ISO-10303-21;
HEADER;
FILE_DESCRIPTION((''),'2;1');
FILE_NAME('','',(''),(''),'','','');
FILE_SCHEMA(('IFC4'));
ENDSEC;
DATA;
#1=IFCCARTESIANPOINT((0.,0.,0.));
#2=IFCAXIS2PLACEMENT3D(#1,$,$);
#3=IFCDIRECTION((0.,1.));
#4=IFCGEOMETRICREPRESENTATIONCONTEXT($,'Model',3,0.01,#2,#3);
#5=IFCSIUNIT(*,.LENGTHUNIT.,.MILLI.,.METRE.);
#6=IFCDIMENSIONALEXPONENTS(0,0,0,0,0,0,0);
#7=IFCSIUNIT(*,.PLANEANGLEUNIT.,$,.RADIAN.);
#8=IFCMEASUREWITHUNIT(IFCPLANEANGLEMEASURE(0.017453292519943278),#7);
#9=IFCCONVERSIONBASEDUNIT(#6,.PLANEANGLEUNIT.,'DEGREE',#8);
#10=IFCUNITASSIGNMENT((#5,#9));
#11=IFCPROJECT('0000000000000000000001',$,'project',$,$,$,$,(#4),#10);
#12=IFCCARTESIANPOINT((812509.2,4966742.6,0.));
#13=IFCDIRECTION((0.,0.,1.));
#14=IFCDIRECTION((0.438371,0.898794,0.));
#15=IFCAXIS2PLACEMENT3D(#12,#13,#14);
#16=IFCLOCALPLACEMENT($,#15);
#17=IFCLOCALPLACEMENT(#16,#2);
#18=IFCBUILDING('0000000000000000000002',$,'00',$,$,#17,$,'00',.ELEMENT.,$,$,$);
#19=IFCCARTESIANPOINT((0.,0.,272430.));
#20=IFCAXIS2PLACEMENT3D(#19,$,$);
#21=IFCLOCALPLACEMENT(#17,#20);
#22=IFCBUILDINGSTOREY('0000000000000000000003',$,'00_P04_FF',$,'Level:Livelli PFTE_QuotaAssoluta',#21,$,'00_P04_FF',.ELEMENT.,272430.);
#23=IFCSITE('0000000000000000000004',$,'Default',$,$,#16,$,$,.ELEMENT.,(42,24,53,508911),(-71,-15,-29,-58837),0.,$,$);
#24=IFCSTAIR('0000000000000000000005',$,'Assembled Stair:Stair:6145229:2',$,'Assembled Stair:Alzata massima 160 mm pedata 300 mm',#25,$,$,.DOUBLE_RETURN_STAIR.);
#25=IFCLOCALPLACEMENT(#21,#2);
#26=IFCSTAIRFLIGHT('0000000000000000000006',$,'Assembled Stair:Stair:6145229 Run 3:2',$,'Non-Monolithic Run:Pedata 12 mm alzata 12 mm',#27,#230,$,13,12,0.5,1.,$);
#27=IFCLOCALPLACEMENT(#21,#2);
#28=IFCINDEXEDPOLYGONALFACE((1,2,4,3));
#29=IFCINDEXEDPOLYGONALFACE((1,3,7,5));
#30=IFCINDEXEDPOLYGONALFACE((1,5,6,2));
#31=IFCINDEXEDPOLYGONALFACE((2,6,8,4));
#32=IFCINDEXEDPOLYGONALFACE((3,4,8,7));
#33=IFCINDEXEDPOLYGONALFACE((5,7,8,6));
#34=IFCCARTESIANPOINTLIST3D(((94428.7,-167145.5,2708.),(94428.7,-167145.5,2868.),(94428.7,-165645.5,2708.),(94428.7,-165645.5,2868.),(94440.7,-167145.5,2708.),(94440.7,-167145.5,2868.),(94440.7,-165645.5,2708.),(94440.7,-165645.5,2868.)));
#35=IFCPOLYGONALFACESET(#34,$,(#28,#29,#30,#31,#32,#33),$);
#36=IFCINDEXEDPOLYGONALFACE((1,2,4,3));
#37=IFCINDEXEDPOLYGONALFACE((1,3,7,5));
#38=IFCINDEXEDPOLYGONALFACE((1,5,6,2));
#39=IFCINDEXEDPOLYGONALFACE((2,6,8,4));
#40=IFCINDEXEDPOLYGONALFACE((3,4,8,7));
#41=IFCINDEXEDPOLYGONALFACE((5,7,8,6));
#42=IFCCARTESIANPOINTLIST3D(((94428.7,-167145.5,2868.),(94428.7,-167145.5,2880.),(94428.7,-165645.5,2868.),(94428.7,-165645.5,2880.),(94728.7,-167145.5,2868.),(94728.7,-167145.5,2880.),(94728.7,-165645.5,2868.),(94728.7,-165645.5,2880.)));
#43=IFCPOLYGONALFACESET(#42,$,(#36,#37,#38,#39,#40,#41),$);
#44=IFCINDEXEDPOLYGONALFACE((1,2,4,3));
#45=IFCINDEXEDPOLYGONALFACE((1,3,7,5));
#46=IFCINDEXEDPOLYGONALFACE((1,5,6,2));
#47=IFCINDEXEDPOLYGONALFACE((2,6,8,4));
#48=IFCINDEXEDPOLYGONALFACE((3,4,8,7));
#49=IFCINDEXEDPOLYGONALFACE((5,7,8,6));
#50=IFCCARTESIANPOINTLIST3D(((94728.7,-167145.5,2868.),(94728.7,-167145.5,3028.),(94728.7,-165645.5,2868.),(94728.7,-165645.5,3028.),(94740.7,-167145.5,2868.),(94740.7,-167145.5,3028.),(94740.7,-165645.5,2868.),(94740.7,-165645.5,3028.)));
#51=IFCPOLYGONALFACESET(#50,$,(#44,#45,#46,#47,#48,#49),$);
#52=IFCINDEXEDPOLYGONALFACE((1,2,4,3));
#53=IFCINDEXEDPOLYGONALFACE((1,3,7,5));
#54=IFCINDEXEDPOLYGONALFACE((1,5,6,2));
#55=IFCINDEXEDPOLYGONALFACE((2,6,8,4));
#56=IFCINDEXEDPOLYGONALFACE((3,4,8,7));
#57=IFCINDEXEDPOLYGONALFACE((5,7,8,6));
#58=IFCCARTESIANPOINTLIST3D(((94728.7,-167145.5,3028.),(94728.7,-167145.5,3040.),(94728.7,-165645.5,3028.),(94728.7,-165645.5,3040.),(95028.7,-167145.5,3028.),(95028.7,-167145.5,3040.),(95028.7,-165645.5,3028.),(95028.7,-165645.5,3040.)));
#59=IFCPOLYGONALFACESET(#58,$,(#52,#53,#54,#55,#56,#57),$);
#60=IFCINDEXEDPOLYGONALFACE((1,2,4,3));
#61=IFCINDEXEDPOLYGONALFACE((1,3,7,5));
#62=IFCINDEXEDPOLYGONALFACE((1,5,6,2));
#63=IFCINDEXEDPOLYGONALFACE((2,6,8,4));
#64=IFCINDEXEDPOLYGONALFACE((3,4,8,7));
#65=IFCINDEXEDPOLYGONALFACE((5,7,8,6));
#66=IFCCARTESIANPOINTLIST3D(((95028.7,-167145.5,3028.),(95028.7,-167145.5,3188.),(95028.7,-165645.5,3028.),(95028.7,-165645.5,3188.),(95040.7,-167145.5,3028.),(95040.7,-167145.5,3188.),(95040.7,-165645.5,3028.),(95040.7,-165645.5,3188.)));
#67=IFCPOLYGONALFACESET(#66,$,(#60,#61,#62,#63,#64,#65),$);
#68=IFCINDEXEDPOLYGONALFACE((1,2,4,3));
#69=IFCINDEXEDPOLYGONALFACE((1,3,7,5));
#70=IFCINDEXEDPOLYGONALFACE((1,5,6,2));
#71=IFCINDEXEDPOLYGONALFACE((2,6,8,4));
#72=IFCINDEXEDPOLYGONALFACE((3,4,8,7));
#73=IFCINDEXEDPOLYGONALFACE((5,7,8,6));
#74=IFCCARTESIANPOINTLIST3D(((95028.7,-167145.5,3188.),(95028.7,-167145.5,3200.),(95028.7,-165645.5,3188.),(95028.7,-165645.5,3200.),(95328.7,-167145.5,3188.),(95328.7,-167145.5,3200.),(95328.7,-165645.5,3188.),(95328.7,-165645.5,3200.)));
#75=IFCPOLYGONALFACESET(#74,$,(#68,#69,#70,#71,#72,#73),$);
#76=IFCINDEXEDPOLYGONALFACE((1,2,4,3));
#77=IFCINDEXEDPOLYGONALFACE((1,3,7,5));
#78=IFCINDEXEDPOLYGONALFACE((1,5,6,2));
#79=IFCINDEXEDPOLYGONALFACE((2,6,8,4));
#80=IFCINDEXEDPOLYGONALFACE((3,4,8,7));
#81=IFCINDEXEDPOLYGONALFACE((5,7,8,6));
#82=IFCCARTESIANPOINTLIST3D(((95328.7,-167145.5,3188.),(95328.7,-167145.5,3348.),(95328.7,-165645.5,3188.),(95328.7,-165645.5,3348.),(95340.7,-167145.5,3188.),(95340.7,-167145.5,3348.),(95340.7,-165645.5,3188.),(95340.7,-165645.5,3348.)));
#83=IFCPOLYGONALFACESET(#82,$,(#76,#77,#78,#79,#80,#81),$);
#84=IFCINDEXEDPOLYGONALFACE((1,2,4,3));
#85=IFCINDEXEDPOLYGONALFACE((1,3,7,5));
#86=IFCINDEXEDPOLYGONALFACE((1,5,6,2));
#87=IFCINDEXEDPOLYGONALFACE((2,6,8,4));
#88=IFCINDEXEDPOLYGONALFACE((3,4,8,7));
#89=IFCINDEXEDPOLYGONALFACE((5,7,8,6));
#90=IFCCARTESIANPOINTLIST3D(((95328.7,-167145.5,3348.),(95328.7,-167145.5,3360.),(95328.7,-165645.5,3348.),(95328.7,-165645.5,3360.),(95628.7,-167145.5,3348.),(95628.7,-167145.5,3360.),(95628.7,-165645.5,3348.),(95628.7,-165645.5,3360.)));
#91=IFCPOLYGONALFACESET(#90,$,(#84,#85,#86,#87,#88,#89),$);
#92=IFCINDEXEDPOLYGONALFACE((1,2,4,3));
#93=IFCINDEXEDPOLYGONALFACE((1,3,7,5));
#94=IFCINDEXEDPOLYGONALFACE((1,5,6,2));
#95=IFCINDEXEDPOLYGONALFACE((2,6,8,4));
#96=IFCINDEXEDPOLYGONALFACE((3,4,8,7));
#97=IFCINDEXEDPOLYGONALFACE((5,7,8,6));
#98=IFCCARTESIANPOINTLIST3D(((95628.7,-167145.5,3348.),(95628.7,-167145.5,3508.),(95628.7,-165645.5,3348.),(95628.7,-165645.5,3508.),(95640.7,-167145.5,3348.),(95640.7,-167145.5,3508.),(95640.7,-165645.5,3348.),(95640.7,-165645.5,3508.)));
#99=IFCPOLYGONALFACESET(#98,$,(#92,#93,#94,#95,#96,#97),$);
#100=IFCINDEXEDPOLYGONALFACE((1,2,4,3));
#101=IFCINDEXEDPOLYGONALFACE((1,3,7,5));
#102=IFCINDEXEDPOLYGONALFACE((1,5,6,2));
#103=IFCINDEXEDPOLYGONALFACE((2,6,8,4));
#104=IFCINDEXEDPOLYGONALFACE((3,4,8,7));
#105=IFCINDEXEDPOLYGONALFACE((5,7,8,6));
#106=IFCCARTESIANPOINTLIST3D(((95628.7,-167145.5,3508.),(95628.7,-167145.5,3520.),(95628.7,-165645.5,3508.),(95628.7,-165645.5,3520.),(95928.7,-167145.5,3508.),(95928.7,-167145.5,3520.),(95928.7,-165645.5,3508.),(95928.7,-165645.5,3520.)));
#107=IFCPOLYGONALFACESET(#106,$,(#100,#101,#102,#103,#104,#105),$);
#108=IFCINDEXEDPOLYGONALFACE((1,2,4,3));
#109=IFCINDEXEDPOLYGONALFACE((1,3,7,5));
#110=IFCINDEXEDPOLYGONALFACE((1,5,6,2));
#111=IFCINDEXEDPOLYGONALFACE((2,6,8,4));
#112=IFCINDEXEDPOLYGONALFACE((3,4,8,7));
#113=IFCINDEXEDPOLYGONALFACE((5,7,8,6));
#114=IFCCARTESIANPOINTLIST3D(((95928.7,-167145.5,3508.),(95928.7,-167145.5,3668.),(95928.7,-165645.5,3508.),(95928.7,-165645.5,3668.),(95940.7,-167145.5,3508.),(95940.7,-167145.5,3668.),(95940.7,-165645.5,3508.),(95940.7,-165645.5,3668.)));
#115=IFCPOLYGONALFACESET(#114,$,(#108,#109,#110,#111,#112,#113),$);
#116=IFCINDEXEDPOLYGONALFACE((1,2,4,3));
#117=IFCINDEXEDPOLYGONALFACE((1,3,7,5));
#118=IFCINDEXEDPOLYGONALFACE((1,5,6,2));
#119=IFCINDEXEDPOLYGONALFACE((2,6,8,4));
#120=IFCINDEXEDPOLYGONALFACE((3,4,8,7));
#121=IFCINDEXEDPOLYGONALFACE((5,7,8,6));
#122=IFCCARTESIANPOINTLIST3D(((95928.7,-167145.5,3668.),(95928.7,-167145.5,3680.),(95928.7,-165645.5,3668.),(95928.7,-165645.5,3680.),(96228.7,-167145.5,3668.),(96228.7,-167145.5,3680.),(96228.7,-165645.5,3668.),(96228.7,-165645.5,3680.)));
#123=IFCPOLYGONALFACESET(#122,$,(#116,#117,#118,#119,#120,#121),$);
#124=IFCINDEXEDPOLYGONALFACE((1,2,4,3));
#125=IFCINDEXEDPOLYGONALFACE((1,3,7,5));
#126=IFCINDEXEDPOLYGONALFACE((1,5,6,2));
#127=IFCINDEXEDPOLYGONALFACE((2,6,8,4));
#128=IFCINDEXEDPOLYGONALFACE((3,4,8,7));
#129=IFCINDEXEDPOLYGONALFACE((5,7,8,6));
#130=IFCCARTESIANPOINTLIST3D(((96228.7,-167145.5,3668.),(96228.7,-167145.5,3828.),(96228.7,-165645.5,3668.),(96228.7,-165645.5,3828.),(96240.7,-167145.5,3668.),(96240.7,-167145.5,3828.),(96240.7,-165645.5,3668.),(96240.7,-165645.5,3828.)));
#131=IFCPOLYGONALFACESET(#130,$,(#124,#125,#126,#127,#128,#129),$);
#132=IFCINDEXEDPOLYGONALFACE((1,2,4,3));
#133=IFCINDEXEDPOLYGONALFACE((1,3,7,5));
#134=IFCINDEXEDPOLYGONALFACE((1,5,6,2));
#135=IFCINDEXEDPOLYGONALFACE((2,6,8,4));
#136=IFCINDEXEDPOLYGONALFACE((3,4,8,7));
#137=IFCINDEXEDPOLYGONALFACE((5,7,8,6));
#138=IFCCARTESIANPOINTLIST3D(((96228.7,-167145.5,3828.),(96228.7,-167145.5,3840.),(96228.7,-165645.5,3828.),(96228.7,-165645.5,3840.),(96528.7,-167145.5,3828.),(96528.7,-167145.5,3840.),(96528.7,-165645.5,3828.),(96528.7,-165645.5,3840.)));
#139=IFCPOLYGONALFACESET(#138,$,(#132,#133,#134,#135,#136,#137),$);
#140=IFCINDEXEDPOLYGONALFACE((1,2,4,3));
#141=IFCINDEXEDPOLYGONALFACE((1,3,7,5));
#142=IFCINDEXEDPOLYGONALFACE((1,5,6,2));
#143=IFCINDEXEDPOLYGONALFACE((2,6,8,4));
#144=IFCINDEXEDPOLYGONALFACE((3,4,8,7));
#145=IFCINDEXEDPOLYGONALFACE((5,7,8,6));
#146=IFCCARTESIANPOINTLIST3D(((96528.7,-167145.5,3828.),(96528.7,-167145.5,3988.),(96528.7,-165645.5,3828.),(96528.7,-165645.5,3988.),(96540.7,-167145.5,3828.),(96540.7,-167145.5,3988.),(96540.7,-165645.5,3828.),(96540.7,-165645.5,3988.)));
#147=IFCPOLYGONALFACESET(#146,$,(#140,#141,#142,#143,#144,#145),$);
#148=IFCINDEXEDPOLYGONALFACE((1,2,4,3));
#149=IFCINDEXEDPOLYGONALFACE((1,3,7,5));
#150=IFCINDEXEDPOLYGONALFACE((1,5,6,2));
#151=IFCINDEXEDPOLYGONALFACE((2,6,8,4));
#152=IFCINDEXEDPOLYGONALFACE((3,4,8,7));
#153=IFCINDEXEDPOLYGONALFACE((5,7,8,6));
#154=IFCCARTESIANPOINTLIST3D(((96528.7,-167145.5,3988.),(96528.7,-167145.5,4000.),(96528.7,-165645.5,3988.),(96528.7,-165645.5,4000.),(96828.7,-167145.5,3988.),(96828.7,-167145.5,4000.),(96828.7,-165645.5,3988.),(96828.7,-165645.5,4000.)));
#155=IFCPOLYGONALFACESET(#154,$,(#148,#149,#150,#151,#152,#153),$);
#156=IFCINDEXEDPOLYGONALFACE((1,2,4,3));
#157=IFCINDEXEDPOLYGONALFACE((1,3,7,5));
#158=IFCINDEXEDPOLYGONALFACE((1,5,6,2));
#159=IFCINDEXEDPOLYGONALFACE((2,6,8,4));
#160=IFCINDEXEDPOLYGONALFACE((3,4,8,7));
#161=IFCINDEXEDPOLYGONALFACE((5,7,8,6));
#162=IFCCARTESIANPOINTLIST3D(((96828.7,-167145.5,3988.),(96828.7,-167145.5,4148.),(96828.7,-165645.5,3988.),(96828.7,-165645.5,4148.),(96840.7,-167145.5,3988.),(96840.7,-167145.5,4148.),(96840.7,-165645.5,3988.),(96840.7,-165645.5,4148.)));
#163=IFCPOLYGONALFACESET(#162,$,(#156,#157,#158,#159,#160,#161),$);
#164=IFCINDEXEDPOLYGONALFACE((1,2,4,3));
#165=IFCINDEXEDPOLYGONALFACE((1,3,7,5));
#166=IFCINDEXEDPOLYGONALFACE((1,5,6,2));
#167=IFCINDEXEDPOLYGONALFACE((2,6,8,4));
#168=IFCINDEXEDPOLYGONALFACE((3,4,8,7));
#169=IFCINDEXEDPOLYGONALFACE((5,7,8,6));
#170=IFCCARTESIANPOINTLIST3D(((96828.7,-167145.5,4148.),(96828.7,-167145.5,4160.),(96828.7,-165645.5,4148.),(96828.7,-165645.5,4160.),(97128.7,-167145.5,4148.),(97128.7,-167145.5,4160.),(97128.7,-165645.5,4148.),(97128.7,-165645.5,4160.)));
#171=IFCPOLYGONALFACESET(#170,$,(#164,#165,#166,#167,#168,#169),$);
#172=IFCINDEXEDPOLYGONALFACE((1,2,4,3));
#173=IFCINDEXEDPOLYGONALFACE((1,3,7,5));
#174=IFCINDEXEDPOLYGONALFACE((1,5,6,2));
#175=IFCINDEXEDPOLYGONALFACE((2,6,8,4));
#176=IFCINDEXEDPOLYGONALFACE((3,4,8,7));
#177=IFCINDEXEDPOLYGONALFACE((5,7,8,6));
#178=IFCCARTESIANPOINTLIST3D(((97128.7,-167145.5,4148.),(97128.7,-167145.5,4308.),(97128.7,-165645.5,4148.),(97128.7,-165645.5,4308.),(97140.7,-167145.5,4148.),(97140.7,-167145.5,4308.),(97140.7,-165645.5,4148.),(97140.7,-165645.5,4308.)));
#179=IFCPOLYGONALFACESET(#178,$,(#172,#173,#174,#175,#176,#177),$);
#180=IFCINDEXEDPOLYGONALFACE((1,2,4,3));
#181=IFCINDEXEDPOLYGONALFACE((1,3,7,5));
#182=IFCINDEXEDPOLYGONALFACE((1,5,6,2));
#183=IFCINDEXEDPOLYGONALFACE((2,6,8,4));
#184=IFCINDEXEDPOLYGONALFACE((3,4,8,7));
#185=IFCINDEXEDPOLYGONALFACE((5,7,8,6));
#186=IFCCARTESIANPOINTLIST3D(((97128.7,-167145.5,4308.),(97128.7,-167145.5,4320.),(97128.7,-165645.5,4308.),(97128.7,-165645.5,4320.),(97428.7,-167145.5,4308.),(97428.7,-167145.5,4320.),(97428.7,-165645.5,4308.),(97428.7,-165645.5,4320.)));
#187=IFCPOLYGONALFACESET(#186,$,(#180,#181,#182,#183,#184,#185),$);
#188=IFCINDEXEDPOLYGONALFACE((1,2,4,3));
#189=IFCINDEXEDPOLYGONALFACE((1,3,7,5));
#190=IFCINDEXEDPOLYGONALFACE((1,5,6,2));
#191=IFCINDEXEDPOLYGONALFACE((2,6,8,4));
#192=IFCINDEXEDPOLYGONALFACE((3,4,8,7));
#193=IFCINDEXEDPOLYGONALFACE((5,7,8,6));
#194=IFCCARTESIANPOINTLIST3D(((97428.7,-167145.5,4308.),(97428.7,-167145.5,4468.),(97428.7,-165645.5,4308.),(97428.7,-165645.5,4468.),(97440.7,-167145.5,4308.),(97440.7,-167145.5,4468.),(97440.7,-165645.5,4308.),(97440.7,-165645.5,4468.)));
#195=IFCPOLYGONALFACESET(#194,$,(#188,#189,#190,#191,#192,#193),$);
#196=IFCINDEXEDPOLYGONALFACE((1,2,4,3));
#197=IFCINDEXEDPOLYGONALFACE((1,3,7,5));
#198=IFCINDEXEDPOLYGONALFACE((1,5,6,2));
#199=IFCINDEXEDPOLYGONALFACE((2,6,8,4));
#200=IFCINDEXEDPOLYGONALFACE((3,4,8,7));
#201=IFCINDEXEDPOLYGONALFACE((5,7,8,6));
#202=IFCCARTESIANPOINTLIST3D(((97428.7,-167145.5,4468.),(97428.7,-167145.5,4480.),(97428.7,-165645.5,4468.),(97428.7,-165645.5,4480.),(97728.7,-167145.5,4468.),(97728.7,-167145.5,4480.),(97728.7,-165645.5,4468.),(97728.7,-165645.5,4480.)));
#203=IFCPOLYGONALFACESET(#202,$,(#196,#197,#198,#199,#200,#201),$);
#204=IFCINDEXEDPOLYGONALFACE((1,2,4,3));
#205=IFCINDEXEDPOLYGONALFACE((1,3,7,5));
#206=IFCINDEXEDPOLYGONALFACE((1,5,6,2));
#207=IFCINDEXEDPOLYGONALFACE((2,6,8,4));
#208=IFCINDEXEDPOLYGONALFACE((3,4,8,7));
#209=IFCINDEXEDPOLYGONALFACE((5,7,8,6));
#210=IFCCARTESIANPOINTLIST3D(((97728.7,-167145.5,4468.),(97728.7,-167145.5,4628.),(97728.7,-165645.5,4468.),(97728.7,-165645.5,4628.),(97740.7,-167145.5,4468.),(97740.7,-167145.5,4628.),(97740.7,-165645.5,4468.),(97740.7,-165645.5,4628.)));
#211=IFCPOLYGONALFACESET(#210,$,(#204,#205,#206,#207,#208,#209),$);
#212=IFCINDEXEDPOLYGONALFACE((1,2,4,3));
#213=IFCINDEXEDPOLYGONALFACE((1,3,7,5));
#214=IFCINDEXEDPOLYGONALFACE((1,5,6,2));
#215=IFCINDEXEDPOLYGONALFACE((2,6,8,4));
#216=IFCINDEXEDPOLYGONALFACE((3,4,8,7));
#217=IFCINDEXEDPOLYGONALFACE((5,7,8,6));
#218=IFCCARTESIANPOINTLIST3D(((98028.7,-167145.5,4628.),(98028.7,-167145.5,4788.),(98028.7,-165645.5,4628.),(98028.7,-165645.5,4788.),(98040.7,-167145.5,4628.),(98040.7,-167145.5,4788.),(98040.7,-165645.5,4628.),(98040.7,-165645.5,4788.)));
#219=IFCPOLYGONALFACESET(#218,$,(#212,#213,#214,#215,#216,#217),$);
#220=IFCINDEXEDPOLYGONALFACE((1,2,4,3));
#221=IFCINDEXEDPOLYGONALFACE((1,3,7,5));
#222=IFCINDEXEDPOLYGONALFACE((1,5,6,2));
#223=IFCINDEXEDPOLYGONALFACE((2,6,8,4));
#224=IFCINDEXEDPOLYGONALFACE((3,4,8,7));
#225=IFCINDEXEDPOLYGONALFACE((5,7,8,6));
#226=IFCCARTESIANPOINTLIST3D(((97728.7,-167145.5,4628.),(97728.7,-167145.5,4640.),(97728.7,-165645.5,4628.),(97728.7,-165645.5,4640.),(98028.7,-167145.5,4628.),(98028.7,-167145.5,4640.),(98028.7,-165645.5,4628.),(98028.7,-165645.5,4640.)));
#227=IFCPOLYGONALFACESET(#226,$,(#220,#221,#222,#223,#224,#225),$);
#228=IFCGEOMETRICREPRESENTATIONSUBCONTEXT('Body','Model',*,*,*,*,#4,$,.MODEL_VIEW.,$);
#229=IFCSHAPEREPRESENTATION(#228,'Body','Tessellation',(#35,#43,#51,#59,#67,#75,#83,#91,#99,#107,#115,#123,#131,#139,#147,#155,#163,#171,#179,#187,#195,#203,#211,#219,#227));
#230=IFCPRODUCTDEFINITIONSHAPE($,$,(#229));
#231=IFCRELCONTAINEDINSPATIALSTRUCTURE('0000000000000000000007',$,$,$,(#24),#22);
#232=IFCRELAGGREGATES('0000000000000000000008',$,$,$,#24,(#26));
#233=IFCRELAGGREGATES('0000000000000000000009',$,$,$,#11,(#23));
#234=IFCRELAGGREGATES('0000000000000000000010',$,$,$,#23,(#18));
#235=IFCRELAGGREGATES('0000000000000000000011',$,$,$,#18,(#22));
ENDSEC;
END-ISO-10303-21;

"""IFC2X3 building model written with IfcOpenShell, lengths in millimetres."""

from ifc_helpers import new_model, entity, si_unit, converted_unit, direction, frame, origin, origin_2d_with_axis, place, context, subcontext, project, spatial, rectangle, extrude, element, aggregate, save


model = new_model("IFC2X3")

# Units and contexts
model_context = context("Model", 3, precision=0.01, world=origin(), true_north=direction((0.0, 1.0)))
body_context = subcontext(model_context, "Body", "Model", "MODEL_VIEW")
ifc_project = project(units=[si_unit("LENGTHUNIT", "METRE", prefix="MILLI"), converted_unit("PLANEANGLEUNIT", "DEGREE", entity("IfcPlaneAngleMeasure", 0.017453292519943278), si_unit("PLANEANGLEUNIT", "RADIAN"), dimensions=[0, 0, 0, 0, 0, 0, 0])], contexts=[model_context])

# Site, building, storey
site_placement = place(None, frame((812509.2, 4966742.6, 0.0), z_axis=(0.0, 0.0, 1.0), x_axis=(0.438371, 0.898794, 0.0)))
site = spatial("IfcSite", under=ifc_project, at=site_placement, Name="Default", CompositionType="ELEMENT", RefLatitude=(42, 24, 53, 508911), RefLongitude=(-71, -15, -29, -58837), RefElevation=0.0)
building_placement = place(site_placement, origin())
building = spatial("IfcBuilding", under=site, at=building_placement, Name="00", LongName="00", CompositionType="ELEMENT")
storey_placement = place(building_placement, frame((0.0, 0.0, 272430.0)))
storey = spatial("IfcBuildingStorey", under=building, at=storey_placement, Name="00_P04_FF", ObjectType="Level:Livelli PFTE_QuotaAssoluta", LongName="00_P04_FF", CompositionType="ELEMENT", Elevation=272430.0)

# Stair
stair_1_placement = place(storey_placement, origin())
stair_1 = element("IfcStair", 1, at=stair_1_placement, inside=storey, Name="Assembled Stair:Stair:6145229:2", ObjectType="Assembled Stair:Alzata massima 160 mm pedata 300 mm", ShapeType="DOUBLE_RETURN_STAIR")

# Stair flight
stair_flight_1_placement = place(stair_1_placement, origin())
stair_flight_1 = element("IfcStairFlight", 2, at=stair_flight_1_placement, Name="Assembled Stair:Stair:6145229 Run 3:2", ObjectType="Non-Monolithic Run:Pedata 12 mm alzata 12 mm", NumberOfRiser=13, NumberOfTreads=12, RiserHeight=0.5, TreadLength=1.0, context=body_context, shape_type="SweptSolid", body=[
    extrude(rectangle(XDim=1500.0, YDim=12.0, at=origin_2d_with_axis()), frame((94434.7, -166395.5, 2708.0), z_axis=(0.0, 0.0, 1.0), x_axis=(0.0, 1.0, 0.0)), (0.0, 0.0, 1.0), 160.0),
    extrude(rectangle(XDim=300.0, YDim=1500.0, at=origin_2d_with_axis()), frame((94578.7, -166395.5, 2868.0), z_axis=(0.0, 0.0, 1.0), x_axis=(-1.0, 0.0, 0.0)), (0.0, 0.0, 1.0), 12.0),
    extrude(rectangle(XDim=1500.0, YDim=12.0, at=origin_2d_with_axis()), frame((94734.7, -166395.5, 2868.0), z_axis=(0.0, 0.0, 1.0), x_axis=(0.0, 1.0, 0.0)), (0.0, 0.0, 1.0), 160.0),
    extrude(rectangle(XDim=300.0, YDim=1500.0, at=origin_2d_with_axis()), frame((94878.7, -166395.5, 3028.0), z_axis=(0.0, 0.0, 1.0), x_axis=(-1.0, 0.0, 0.0)), (0.0, 0.0, 1.0), 12.0),
    extrude(rectangle(XDim=1500.0, YDim=12.0, at=origin_2d_with_axis()), frame((95034.7, -166395.5, 3028.0), z_axis=(0.0, 0.0, 1.0), x_axis=(0.0, 1.0, 0.0)), (0.0, 0.0, 1.0), 160.0),
    extrude(rectangle(XDim=300.0, YDim=1500.0, at=origin_2d_with_axis()), frame((95178.7, -166395.5, 3188.0), z_axis=(0.0, 0.0, 1.0), x_axis=(-1.0, 0.0, 0.0)), (0.0, 0.0, 1.0), 12.0),
    extrude(rectangle(XDim=1500.0, YDim=12.0, at=origin_2d_with_axis()), frame((95334.7, -166395.5, 3188.0), z_axis=(0.0, 0.0, 1.0), x_axis=(0.0, 1.0, 0.0)), (0.0, 0.0, 1.0), 160.0),
    extrude(rectangle(XDim=300.0, YDim=1500.0, at=origin_2d_with_axis()), frame((95478.7, -166395.5, 3348.0), z_axis=(0.0, 0.0, 1.0), x_axis=(-1.0, 0.0, 0.0)), (0.0, 0.0, 1.0), 12.0),
    extrude(rectangle(XDim=1500.0, YDim=12.0, at=origin_2d_with_axis()), frame((95634.7, -166395.5, 3348.0), z_axis=(0.0, 0.0, 1.0), x_axis=(0.0, 1.0, 0.0)), (0.0, 0.0, 1.0), 160.0),
    extrude(rectangle(XDim=300.0, YDim=1500.0, at=origin_2d_with_axis()), frame((95778.7, -166395.5, 3508.0), z_axis=(0.0, 0.0, 1.0), x_axis=(-1.0, 0.0, 0.0)), (0.0, 0.0, 1.0), 12.0),
    extrude(rectangle(XDim=1500.0, YDim=12.0, at=origin_2d_with_axis()), frame((95934.7, -166395.5, 3508.0), z_axis=(0.0, 0.0, 1.0), x_axis=(0.0, 1.0, 0.0)), (0.0, 0.0, 1.0), 160.0),
    extrude(rectangle(XDim=300.0, YDim=1500.0, at=origin_2d_with_axis()), frame((96078.7, -166395.5, 3668.0), z_axis=(0.0, 0.0, 1.0), x_axis=(-1.0, 0.0, 0.0)), (0.0, 0.0, 1.0), 12.0),
    extrude(rectangle(XDim=1500.0, YDim=12.0, at=origin_2d_with_axis()), frame((96234.7, -166395.5, 3668.0), z_axis=(0.0, 0.0, 1.0), x_axis=(0.0, 1.0, 0.0)), (0.0, 0.0, 1.0), 160.0),
    extrude(rectangle(XDim=300.0, YDim=1500.0, at=origin_2d_with_axis()), frame((96378.7, -166395.5, 3828.0), z_axis=(0.0, 0.0, 1.0), x_axis=(-1.0, 0.0, 0.0)), (0.0, 0.0, 1.0), 12.0),
    extrude(rectangle(XDim=1500.0, YDim=12.0, at=origin_2d_with_axis()), frame((96534.7, -166395.5, 3828.0), z_axis=(0.0, 0.0, 1.0), x_axis=(0.0, 1.0, 0.0)), (0.0, 0.0, 1.0), 160.0),
    extrude(rectangle(XDim=300.0, YDim=1500.0, at=origin_2d_with_axis()), frame((96678.7, -166395.5, 3988.0), z_axis=(0.0, 0.0, 1.0), x_axis=(-1.0, 0.0, 0.0)), (0.0, 0.0, 1.0), 12.0),
    extrude(rectangle(XDim=1500.0, YDim=12.0, at=origin_2d_with_axis()), frame((96834.7, -166395.5, 3988.0), z_axis=(0.0, 0.0, 1.0), x_axis=(0.0, 1.0, 0.0)), (0.0, 0.0, 1.0), 160.0),
    extrude(rectangle(XDim=300.0, YDim=1500.0, at=origin_2d_with_axis()), frame((96978.7, -166395.5, 4148.0), z_axis=(0.0, 0.0, 1.0), x_axis=(-1.0, 0.0, 0.0)), (0.0, 0.0, 1.0), 12.0),
    extrude(rectangle(XDim=1500.0, YDim=12.0, at=origin_2d_with_axis()), frame((97134.7, -166395.5, 4148.0), z_axis=(0.0, 0.0, 1.0), x_axis=(0.0, 1.0, 0.0)), (0.0, 0.0, 1.0), 160.0),
    extrude(rectangle(XDim=300.0, YDim=1500.0, at=origin_2d_with_axis()), frame((97278.7, -166395.5, 4308.0), z_axis=(0.0, 0.0, 1.0), x_axis=(-1.0, 0.0, 0.0)), (0.0, 0.0, 1.0), 12.0),
    extrude(rectangle(XDim=1500.0, YDim=12.0, at=origin_2d_with_axis()), frame((97434.7, -166395.5, 4308.0), z_axis=(0.0, 0.0, 1.0), x_axis=(0.0, 1.0, 0.0)), (0.0, 0.0, 1.0), 160.0),
    extrude(rectangle(XDim=300.0, YDim=1500.0, at=origin_2d_with_axis()), frame((97578.7, -166395.5, 4468.0), z_axis=(0.0, 0.0, 1.0), x_axis=(-1.0, 0.0, 0.0)), (0.0, 0.0, 1.0), 12.0),
    extrude(rectangle(XDim=1500.0, YDim=12.0, at=origin_2d_with_axis()), frame((97734.7, -166395.5, 4468.0), z_axis=(0.0, 0.0, 1.0), x_axis=(0.0, 1.0, 0.0)), (0.0, 0.0, 1.0), 160.0),
    extrude(rectangle(XDim=1500.0, YDim=12.0, at=origin_2d_with_axis()), frame((98034.7, -166395.5, 4628.0), z_axis=(0.0, 0.0, 1.0), x_axis=(0.0, 1.0, 0.0)), (0.0, 0.0, 1.0), 160.0),
    extrude(rectangle(XDim=300.0, YDim=1500.0, at=origin_2d_with_axis()), frame((97878.7, -166395.5, 4628.0), z_axis=(0.0, 0.0, 1.0), x_axis=(-1.0, 0.0, 0.0)), (0.0, 0.0, 1.0), 12.0),
])
aggregate(stair_1, [stair_flight_1])

save(model, "model.ifc")
